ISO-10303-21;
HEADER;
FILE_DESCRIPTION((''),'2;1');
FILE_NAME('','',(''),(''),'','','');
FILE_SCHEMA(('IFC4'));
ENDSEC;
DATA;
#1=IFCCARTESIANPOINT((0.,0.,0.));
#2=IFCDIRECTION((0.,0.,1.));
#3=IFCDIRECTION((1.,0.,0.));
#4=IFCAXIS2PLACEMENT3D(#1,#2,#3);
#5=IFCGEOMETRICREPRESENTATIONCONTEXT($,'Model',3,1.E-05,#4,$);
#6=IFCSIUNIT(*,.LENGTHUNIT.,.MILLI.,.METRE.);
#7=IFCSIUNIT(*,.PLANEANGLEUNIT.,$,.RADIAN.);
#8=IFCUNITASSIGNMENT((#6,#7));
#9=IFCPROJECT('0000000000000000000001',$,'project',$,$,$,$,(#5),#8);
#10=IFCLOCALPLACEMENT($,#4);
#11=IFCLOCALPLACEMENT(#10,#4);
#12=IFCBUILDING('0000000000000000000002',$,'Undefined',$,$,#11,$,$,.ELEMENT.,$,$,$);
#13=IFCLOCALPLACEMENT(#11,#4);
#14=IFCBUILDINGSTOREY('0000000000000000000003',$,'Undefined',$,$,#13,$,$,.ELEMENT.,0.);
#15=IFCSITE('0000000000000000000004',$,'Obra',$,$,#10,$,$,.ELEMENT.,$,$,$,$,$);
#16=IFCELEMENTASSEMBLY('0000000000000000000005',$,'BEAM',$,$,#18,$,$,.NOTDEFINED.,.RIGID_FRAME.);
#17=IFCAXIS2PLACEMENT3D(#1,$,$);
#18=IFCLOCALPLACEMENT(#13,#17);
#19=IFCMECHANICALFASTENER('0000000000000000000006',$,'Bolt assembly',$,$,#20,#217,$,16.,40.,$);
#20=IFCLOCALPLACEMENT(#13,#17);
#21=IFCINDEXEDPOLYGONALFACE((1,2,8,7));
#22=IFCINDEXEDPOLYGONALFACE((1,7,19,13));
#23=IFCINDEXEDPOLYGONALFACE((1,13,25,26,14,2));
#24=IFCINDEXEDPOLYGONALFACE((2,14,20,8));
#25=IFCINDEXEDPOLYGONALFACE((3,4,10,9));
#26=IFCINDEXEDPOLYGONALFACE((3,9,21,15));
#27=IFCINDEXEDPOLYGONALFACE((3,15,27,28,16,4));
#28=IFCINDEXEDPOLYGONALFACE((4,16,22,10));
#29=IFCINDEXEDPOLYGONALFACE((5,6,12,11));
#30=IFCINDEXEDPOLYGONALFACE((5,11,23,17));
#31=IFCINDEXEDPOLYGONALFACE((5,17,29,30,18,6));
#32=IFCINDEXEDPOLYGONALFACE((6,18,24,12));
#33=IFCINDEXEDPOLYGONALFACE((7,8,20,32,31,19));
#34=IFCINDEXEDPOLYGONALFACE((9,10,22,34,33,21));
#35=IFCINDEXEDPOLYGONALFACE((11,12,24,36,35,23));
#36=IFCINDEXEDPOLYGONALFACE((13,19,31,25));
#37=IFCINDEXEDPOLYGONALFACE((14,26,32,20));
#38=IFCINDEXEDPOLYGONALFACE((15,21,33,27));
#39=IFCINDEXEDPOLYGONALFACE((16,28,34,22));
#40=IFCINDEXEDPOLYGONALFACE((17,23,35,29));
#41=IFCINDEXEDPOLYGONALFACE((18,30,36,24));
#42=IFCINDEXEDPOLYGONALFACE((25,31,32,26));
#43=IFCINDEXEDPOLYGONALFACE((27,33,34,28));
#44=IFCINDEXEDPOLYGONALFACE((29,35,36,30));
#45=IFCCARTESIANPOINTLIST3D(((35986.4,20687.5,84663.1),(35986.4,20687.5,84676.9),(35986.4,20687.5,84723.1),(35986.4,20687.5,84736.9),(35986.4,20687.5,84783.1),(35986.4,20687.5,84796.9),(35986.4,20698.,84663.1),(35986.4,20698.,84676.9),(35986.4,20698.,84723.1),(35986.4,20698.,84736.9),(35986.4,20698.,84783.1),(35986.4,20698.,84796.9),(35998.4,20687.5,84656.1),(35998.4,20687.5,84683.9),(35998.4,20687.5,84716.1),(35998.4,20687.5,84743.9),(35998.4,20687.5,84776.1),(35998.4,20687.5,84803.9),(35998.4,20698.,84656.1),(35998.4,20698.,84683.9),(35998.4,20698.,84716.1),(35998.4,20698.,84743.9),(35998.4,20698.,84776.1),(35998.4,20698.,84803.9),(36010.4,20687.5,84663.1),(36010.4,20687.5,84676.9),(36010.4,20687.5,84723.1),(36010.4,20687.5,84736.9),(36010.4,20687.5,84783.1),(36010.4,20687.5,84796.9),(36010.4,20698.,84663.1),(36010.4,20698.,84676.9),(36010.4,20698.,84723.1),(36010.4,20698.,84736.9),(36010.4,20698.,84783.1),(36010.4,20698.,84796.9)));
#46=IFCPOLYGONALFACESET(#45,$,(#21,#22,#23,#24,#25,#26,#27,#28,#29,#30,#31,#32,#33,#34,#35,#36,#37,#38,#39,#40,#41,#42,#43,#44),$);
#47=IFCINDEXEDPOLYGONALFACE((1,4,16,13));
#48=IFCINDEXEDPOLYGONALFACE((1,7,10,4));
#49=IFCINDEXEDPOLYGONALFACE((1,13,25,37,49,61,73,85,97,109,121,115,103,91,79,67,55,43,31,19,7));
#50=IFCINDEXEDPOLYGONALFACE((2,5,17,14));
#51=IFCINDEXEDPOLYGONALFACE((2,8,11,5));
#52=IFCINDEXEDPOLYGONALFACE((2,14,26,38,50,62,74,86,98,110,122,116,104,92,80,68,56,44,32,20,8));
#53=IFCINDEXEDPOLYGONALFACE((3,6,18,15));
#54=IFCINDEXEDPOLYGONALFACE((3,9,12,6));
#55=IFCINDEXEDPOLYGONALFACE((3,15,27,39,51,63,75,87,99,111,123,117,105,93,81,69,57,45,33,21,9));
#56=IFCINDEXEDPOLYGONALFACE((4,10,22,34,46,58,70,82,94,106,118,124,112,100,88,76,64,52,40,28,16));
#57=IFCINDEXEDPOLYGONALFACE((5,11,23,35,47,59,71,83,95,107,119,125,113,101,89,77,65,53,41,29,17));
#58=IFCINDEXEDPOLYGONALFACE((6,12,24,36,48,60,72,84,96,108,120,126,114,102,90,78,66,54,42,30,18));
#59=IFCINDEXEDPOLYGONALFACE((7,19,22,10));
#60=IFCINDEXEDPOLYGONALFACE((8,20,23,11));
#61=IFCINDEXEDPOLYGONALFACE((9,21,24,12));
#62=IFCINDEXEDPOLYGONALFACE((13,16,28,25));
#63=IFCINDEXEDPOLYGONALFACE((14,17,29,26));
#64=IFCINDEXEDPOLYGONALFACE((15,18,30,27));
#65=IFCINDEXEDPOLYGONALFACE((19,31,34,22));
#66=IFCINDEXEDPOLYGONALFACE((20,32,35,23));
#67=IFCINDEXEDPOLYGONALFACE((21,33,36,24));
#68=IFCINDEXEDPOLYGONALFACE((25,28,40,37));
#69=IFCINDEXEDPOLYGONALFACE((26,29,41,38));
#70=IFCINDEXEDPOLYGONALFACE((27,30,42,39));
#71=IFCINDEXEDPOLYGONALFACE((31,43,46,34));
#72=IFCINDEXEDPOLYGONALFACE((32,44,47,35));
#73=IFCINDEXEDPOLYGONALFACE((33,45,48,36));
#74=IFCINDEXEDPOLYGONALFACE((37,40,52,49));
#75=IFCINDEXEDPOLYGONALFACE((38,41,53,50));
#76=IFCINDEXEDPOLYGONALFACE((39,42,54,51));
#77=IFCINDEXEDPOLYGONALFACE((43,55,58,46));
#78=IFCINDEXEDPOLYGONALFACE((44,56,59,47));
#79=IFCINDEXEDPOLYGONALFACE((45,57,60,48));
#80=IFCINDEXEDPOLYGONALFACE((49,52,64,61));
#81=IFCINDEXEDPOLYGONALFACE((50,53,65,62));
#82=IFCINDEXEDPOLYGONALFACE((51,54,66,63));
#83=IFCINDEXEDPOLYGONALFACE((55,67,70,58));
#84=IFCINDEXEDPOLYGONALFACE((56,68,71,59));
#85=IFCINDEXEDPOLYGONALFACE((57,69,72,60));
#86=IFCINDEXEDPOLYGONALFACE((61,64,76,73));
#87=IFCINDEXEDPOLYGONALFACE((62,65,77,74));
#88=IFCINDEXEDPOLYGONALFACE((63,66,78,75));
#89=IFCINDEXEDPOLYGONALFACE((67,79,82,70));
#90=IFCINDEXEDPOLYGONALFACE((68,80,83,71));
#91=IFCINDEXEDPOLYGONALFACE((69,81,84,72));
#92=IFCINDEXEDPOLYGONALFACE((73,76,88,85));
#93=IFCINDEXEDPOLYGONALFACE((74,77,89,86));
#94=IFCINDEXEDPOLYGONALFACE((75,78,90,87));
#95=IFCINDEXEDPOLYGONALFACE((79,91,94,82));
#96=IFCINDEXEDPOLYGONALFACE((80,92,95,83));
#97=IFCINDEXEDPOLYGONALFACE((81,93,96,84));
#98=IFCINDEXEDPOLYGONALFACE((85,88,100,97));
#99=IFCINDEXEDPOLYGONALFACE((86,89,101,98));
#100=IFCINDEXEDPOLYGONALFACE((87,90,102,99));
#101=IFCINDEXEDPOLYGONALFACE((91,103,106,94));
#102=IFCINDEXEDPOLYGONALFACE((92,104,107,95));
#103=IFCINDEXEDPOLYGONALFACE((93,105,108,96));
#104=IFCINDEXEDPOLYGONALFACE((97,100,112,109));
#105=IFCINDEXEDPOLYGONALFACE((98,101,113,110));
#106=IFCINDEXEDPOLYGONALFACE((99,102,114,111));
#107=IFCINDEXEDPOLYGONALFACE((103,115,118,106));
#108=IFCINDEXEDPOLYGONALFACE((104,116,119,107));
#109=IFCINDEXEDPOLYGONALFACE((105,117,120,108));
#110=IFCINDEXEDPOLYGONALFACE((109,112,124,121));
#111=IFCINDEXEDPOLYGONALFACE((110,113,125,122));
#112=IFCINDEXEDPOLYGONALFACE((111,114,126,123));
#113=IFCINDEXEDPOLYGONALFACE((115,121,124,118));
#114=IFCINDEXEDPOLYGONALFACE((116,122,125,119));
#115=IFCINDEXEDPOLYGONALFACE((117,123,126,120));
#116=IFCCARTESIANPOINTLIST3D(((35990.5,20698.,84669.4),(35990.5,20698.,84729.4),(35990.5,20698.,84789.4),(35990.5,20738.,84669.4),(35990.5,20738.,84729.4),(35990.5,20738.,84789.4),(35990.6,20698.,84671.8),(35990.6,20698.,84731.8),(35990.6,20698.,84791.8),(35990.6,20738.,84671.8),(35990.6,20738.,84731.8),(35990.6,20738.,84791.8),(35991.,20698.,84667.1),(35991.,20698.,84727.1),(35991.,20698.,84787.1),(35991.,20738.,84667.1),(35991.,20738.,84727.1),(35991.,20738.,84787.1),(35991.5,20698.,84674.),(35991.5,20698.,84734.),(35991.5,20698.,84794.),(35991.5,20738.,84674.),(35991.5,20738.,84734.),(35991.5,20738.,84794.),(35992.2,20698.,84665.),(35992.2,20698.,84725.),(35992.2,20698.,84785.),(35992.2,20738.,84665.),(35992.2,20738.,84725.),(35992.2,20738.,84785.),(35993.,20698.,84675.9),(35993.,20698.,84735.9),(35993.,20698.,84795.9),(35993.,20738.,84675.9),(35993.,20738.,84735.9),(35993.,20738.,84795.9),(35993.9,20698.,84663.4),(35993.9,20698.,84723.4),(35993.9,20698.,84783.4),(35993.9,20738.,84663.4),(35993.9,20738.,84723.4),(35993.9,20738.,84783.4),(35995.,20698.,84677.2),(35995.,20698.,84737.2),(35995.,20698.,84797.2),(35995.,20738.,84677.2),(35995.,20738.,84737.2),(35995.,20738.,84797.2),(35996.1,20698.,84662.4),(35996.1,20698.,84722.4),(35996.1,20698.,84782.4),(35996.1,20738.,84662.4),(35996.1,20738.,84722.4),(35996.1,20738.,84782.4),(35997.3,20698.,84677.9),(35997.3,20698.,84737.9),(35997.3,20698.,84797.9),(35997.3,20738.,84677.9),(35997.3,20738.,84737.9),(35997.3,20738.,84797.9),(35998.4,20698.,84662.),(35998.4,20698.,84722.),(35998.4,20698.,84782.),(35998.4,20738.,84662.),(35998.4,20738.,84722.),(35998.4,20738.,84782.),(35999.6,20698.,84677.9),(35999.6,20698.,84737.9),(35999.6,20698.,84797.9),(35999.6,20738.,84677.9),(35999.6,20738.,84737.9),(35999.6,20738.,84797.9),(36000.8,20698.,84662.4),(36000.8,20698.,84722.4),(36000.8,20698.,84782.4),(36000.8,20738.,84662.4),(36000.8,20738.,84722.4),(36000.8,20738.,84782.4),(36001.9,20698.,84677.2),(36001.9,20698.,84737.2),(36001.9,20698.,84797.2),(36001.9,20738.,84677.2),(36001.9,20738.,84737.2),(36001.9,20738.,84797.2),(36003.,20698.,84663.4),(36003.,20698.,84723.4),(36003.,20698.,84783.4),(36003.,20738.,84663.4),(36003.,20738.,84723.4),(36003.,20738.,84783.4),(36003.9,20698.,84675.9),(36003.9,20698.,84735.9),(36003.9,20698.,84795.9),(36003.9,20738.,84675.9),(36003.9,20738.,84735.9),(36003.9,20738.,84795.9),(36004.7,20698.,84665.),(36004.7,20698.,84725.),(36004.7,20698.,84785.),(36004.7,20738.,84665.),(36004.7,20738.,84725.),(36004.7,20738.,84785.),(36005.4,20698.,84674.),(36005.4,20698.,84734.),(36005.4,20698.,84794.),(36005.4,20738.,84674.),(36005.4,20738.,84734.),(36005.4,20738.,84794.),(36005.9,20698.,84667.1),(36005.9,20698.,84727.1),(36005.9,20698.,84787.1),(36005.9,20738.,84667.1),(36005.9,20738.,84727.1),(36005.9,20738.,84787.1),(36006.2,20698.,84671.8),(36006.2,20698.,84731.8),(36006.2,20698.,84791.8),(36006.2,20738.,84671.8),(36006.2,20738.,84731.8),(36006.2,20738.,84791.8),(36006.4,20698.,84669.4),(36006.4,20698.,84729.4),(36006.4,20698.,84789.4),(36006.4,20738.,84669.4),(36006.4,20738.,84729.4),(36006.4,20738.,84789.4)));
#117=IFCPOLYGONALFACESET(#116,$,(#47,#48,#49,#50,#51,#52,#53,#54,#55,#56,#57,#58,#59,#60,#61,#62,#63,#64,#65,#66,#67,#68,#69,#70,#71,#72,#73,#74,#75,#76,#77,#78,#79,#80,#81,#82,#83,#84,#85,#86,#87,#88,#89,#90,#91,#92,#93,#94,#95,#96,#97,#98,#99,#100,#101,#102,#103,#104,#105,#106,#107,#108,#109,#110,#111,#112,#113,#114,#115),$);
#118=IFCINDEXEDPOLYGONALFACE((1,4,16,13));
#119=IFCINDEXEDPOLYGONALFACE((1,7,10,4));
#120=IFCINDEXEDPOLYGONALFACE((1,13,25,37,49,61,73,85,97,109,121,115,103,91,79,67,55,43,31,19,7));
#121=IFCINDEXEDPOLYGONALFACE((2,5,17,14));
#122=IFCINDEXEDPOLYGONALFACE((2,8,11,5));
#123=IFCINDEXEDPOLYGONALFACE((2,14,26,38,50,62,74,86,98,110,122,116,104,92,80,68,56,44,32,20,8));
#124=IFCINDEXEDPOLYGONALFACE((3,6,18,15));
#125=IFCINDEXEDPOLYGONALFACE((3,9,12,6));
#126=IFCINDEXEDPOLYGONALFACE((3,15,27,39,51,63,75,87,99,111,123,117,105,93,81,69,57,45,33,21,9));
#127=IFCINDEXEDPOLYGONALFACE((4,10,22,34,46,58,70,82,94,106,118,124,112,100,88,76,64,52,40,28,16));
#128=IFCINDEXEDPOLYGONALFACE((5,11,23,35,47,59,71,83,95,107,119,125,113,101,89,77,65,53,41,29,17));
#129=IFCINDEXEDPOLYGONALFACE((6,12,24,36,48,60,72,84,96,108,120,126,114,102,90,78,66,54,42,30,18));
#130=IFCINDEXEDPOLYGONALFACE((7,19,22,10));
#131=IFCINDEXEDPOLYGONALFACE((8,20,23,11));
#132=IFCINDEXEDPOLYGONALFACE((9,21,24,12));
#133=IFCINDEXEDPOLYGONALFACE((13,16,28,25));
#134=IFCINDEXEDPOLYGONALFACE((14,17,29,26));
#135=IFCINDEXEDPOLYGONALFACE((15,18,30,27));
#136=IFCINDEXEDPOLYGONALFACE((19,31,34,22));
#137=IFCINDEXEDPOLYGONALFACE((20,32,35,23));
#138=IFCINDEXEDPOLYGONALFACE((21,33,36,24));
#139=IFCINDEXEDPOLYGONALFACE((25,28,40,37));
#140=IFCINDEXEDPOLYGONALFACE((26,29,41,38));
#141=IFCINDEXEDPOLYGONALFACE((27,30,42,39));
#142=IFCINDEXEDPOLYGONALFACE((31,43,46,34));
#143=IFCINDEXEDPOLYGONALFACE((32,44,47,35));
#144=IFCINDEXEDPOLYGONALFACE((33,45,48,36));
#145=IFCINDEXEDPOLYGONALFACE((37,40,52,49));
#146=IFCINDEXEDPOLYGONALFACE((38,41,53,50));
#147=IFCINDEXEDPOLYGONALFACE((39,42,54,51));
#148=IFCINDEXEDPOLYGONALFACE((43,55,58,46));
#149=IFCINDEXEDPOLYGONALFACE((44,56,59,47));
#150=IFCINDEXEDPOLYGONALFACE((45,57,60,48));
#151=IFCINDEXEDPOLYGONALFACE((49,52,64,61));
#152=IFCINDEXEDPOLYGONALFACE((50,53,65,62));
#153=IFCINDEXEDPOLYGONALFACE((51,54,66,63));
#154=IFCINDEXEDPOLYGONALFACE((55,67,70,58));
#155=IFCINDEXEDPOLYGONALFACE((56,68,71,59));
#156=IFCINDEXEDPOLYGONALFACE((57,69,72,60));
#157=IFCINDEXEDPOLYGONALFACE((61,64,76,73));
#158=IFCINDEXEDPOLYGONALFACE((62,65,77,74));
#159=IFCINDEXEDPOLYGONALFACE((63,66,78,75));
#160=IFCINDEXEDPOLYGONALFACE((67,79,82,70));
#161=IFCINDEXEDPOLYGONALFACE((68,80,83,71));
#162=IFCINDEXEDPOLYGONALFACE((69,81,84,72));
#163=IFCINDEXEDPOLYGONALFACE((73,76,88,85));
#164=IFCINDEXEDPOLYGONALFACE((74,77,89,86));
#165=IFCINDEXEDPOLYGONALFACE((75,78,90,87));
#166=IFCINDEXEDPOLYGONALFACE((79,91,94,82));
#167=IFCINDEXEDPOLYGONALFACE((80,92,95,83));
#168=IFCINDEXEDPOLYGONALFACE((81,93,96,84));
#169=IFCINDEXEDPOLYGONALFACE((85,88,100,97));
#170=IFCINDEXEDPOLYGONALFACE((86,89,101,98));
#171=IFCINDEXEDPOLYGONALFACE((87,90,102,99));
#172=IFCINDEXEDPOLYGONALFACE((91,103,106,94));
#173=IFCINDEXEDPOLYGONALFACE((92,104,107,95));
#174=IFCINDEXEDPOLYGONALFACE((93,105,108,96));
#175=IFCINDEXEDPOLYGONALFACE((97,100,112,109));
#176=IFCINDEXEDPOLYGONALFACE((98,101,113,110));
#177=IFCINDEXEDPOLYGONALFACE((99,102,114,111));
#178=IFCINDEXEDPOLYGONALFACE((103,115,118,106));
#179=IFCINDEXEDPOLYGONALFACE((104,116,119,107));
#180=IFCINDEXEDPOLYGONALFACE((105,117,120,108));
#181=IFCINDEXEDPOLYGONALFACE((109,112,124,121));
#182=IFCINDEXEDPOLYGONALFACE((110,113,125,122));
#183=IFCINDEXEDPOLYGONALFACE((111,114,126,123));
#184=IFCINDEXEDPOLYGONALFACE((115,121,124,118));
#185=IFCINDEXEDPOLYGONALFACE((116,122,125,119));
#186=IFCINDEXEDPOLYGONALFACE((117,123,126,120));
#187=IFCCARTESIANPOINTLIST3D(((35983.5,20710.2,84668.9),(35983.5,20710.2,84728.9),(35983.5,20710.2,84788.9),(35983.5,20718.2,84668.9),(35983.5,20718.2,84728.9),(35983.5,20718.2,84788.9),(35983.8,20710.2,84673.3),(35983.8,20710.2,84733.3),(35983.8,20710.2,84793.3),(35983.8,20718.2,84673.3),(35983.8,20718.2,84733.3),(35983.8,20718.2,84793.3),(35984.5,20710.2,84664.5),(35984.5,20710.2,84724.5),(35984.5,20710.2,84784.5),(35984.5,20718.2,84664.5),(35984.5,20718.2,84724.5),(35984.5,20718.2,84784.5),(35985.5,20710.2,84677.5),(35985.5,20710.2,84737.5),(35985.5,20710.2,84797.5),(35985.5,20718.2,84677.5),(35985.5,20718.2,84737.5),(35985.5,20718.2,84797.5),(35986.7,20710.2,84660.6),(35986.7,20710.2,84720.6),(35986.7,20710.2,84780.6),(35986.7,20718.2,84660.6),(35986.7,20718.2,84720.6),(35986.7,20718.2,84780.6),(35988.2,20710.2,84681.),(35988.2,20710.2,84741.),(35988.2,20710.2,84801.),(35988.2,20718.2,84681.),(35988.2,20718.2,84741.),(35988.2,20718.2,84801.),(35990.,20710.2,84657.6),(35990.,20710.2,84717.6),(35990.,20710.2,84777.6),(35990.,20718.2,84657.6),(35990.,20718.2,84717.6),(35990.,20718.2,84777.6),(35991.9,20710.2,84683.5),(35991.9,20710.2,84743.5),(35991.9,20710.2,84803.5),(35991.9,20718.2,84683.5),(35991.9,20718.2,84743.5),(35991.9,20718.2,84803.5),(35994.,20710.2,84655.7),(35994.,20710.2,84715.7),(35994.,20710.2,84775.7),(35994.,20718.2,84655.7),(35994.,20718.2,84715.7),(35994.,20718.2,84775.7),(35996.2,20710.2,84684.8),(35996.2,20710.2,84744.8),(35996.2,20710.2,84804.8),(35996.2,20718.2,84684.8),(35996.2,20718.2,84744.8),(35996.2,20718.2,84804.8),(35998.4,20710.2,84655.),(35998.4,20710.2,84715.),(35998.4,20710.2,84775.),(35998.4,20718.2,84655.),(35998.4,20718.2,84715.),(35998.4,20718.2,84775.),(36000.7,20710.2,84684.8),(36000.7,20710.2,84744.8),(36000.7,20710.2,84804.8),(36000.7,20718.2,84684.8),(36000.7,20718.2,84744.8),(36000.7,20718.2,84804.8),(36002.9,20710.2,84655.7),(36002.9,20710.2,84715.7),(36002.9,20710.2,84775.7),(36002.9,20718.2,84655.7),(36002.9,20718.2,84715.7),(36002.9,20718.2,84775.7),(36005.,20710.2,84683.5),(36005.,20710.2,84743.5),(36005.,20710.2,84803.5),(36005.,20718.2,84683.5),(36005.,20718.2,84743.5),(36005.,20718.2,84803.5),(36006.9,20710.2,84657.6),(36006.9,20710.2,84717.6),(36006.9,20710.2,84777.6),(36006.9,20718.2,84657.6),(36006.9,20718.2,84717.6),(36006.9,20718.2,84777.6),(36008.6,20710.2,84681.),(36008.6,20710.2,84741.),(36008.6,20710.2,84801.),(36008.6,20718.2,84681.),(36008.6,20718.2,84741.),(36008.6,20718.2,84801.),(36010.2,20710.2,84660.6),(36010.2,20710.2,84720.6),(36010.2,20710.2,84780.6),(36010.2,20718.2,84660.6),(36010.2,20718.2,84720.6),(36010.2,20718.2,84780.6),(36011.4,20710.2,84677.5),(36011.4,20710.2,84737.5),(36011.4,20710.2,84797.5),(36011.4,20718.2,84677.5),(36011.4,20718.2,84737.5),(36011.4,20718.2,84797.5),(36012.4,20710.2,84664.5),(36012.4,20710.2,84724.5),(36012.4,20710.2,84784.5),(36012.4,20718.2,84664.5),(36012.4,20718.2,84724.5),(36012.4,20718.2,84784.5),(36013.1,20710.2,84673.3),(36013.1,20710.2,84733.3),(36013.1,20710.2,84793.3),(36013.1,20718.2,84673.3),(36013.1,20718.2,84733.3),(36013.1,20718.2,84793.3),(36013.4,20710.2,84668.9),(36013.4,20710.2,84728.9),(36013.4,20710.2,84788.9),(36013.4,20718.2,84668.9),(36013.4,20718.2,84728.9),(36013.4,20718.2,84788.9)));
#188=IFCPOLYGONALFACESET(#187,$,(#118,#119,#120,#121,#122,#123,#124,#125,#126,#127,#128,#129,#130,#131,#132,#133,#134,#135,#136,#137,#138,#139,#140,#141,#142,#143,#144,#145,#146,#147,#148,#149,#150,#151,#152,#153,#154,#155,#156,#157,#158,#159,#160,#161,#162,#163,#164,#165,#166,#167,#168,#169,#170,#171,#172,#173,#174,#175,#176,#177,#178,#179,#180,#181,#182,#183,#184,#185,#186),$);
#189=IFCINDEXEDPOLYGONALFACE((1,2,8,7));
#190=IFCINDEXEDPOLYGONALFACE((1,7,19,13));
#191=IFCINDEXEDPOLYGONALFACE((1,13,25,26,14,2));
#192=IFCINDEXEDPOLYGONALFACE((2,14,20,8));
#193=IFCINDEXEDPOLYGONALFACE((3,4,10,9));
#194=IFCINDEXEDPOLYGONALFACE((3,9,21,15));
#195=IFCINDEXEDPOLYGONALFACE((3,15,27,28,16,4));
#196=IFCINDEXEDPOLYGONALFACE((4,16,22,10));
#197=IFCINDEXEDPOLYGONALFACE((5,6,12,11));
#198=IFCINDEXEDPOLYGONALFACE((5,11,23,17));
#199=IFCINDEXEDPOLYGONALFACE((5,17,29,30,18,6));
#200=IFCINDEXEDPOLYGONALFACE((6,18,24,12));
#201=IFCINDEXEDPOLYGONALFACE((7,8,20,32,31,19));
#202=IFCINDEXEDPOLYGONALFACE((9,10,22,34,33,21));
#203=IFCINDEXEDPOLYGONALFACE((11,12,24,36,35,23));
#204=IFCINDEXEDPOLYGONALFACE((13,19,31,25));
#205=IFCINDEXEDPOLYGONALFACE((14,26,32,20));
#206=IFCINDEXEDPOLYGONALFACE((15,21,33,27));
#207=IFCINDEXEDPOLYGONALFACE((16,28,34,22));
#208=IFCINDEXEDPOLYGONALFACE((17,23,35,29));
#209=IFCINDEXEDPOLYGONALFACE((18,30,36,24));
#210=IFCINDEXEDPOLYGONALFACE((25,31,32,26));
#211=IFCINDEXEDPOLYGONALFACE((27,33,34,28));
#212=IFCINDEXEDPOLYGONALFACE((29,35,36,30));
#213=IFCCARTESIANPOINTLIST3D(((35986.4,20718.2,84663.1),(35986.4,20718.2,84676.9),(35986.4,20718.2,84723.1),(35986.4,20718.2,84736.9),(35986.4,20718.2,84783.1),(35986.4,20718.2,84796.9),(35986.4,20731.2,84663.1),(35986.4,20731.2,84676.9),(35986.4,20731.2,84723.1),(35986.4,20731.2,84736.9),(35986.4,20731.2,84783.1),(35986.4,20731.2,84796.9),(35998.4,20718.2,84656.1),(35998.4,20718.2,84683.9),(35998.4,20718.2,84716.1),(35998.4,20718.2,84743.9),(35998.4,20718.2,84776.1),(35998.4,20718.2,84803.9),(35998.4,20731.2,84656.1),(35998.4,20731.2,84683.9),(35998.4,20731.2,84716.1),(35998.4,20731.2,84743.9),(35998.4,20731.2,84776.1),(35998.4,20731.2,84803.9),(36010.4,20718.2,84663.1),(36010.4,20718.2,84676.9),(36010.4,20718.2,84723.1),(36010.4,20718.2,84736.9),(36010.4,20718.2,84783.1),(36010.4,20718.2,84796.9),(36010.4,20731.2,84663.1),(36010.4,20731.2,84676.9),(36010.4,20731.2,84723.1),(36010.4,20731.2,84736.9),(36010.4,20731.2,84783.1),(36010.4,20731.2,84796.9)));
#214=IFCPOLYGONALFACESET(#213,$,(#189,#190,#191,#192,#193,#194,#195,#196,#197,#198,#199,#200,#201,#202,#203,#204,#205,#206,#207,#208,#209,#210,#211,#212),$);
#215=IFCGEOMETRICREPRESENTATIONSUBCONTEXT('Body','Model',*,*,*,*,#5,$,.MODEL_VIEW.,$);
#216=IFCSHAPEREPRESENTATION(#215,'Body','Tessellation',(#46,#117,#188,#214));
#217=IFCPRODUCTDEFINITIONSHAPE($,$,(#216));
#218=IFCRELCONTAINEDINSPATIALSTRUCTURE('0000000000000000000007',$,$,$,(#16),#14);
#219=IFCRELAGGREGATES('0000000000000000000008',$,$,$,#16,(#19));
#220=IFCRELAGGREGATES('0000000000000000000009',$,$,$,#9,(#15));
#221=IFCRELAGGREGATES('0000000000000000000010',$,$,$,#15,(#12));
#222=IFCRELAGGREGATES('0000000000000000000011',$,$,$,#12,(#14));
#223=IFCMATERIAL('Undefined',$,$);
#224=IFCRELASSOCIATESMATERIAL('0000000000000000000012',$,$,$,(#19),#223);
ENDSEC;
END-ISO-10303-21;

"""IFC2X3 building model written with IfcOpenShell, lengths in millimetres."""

from ifc_helpers import new_model, si_unit, frame, origin_with_axes, origin_2d_with_axis, place, context, subcontext, project, spatial, polyline, circle, outline, extrude, source, transform, mapped, material, element, aggregate, save


model = new_model("IFC2X3")

# Units and contexts
model_context = context("Model", 3, precision=1e-05, world=origin_with_axes())
body_context = subcontext(model_context, "Body", "Model", "MODEL_VIEW")
ifc_project = project(units=[si_unit("LENGTHUNIT", "METRE", prefix="MILLI"), si_unit("PLANEANGLEUNIT", "RADIAN")], contexts=[model_context])

# Site, building, storey
site_placement = place(None, origin_with_axes())
site = spatial("IfcSite", under=ifc_project, at=site_placement, Name="Obra", CompositionType="ELEMENT")
building_placement = place(site_placement, origin_with_axes())
building = spatial("IfcBuilding", under=site, at=building_placement, Name="Undefined", CompositionType="ELEMENT")
storey_placement = place(building_placement, origin_with_axes())
storey = spatial("IfcBuildingStorey", under=building, at=storey_placement, Name="Undefined", CompositionType="ELEMENT", Elevation=0.0)

# Shared definitions
ifc_material_1 = material(Name="Undefined")

# Element assembly, mechanical fastener
assembly_1_placement = place(storey_placement, origin_with_axes())
assembly_1 = element("IfcElementAssembly", 1, at=assembly_1_placement, inside=storey, Name="BEAM", AssemblyPlace="NOTDEFINED", PredefinedType="RIGID_FRAME")
shared_shape_1 = source(origin_with_axes(), body_context, "Body", "SweptSolid", [
    extrude(outline(polyline([(13.9, 0.0), (6.9, 12.0), (-6.9, 12.0), (-13.9, 0.0), (-6.9, -12.0), (6.9, -12.0), (13.9, 0.0)])), frame((0.0, -19.7, 0.0), z_axis=(0.0, 1.0, 0.0), x_axis=(1.0, 0.0, 0.0)), (0.0, 0.0, 1.0), 10.6),
    extrude(circle(Radius=8.0, at=origin_2d_with_axis()), frame((0.0, -9.1, 0.0), z_axis=(0.0, 1.0, 0.0), x_axis=(1.0, 0.0, 0.0)), (0.0, 0.0, 1.0), 40.0),
    extrude(circle(Radius=15.0, at=origin_2d_with_axis()), frame((0.0, 3.0, 0.0), z_axis=(0.0, 1.0, 0.0), x_axis=(1.0, 0.0, 0.0)), (0.0, 0.0, 1.0), 8.0),
    extrude(outline(polyline([(13.9, 0.0), (6.9, 12.0), (-6.9, 12.0), (-13.9, 0.0), (-6.9, -12.0), (6.9, -12.0), (13.9, 0.0)])), frame((0.0, 11.0, 0.0), z_axis=(0.0, 1.0, 0.0), x_axis=(1.0, 0.0, 0.0)), (0.0, 0.0, 1.0), 13.0),
])
mechanical_fastener_1_placement = place(assembly_1_placement, frame((35948.4, 20707.1, 84850.0), z_axis=(1.0, 0.0, 0.0), x_axis=(0.0, 0.0, -1.0)))
mechanical_fastener_1 = element("IfcMechanicalFastener", 2, at=mechanical_fastener_1_placement, material=ifc_material_1, Name="Bolt assembly", NominalDiameter=16.0, NominalLength=40.0, context=body_context, shape_type="MappedRepresentation", body=[
    mapped(shared_shape_1, transform((60.0, 0.0, 50.0))),
    mapped(shared_shape_1, transform((120.0, 0.0, 50.0))),
    mapped(shared_shape_1, transform((180.0, 0.0, 50.0))),
])
aggregate(assembly_1, [mechanical_fastener_1])

save(model, "model.ifc")
